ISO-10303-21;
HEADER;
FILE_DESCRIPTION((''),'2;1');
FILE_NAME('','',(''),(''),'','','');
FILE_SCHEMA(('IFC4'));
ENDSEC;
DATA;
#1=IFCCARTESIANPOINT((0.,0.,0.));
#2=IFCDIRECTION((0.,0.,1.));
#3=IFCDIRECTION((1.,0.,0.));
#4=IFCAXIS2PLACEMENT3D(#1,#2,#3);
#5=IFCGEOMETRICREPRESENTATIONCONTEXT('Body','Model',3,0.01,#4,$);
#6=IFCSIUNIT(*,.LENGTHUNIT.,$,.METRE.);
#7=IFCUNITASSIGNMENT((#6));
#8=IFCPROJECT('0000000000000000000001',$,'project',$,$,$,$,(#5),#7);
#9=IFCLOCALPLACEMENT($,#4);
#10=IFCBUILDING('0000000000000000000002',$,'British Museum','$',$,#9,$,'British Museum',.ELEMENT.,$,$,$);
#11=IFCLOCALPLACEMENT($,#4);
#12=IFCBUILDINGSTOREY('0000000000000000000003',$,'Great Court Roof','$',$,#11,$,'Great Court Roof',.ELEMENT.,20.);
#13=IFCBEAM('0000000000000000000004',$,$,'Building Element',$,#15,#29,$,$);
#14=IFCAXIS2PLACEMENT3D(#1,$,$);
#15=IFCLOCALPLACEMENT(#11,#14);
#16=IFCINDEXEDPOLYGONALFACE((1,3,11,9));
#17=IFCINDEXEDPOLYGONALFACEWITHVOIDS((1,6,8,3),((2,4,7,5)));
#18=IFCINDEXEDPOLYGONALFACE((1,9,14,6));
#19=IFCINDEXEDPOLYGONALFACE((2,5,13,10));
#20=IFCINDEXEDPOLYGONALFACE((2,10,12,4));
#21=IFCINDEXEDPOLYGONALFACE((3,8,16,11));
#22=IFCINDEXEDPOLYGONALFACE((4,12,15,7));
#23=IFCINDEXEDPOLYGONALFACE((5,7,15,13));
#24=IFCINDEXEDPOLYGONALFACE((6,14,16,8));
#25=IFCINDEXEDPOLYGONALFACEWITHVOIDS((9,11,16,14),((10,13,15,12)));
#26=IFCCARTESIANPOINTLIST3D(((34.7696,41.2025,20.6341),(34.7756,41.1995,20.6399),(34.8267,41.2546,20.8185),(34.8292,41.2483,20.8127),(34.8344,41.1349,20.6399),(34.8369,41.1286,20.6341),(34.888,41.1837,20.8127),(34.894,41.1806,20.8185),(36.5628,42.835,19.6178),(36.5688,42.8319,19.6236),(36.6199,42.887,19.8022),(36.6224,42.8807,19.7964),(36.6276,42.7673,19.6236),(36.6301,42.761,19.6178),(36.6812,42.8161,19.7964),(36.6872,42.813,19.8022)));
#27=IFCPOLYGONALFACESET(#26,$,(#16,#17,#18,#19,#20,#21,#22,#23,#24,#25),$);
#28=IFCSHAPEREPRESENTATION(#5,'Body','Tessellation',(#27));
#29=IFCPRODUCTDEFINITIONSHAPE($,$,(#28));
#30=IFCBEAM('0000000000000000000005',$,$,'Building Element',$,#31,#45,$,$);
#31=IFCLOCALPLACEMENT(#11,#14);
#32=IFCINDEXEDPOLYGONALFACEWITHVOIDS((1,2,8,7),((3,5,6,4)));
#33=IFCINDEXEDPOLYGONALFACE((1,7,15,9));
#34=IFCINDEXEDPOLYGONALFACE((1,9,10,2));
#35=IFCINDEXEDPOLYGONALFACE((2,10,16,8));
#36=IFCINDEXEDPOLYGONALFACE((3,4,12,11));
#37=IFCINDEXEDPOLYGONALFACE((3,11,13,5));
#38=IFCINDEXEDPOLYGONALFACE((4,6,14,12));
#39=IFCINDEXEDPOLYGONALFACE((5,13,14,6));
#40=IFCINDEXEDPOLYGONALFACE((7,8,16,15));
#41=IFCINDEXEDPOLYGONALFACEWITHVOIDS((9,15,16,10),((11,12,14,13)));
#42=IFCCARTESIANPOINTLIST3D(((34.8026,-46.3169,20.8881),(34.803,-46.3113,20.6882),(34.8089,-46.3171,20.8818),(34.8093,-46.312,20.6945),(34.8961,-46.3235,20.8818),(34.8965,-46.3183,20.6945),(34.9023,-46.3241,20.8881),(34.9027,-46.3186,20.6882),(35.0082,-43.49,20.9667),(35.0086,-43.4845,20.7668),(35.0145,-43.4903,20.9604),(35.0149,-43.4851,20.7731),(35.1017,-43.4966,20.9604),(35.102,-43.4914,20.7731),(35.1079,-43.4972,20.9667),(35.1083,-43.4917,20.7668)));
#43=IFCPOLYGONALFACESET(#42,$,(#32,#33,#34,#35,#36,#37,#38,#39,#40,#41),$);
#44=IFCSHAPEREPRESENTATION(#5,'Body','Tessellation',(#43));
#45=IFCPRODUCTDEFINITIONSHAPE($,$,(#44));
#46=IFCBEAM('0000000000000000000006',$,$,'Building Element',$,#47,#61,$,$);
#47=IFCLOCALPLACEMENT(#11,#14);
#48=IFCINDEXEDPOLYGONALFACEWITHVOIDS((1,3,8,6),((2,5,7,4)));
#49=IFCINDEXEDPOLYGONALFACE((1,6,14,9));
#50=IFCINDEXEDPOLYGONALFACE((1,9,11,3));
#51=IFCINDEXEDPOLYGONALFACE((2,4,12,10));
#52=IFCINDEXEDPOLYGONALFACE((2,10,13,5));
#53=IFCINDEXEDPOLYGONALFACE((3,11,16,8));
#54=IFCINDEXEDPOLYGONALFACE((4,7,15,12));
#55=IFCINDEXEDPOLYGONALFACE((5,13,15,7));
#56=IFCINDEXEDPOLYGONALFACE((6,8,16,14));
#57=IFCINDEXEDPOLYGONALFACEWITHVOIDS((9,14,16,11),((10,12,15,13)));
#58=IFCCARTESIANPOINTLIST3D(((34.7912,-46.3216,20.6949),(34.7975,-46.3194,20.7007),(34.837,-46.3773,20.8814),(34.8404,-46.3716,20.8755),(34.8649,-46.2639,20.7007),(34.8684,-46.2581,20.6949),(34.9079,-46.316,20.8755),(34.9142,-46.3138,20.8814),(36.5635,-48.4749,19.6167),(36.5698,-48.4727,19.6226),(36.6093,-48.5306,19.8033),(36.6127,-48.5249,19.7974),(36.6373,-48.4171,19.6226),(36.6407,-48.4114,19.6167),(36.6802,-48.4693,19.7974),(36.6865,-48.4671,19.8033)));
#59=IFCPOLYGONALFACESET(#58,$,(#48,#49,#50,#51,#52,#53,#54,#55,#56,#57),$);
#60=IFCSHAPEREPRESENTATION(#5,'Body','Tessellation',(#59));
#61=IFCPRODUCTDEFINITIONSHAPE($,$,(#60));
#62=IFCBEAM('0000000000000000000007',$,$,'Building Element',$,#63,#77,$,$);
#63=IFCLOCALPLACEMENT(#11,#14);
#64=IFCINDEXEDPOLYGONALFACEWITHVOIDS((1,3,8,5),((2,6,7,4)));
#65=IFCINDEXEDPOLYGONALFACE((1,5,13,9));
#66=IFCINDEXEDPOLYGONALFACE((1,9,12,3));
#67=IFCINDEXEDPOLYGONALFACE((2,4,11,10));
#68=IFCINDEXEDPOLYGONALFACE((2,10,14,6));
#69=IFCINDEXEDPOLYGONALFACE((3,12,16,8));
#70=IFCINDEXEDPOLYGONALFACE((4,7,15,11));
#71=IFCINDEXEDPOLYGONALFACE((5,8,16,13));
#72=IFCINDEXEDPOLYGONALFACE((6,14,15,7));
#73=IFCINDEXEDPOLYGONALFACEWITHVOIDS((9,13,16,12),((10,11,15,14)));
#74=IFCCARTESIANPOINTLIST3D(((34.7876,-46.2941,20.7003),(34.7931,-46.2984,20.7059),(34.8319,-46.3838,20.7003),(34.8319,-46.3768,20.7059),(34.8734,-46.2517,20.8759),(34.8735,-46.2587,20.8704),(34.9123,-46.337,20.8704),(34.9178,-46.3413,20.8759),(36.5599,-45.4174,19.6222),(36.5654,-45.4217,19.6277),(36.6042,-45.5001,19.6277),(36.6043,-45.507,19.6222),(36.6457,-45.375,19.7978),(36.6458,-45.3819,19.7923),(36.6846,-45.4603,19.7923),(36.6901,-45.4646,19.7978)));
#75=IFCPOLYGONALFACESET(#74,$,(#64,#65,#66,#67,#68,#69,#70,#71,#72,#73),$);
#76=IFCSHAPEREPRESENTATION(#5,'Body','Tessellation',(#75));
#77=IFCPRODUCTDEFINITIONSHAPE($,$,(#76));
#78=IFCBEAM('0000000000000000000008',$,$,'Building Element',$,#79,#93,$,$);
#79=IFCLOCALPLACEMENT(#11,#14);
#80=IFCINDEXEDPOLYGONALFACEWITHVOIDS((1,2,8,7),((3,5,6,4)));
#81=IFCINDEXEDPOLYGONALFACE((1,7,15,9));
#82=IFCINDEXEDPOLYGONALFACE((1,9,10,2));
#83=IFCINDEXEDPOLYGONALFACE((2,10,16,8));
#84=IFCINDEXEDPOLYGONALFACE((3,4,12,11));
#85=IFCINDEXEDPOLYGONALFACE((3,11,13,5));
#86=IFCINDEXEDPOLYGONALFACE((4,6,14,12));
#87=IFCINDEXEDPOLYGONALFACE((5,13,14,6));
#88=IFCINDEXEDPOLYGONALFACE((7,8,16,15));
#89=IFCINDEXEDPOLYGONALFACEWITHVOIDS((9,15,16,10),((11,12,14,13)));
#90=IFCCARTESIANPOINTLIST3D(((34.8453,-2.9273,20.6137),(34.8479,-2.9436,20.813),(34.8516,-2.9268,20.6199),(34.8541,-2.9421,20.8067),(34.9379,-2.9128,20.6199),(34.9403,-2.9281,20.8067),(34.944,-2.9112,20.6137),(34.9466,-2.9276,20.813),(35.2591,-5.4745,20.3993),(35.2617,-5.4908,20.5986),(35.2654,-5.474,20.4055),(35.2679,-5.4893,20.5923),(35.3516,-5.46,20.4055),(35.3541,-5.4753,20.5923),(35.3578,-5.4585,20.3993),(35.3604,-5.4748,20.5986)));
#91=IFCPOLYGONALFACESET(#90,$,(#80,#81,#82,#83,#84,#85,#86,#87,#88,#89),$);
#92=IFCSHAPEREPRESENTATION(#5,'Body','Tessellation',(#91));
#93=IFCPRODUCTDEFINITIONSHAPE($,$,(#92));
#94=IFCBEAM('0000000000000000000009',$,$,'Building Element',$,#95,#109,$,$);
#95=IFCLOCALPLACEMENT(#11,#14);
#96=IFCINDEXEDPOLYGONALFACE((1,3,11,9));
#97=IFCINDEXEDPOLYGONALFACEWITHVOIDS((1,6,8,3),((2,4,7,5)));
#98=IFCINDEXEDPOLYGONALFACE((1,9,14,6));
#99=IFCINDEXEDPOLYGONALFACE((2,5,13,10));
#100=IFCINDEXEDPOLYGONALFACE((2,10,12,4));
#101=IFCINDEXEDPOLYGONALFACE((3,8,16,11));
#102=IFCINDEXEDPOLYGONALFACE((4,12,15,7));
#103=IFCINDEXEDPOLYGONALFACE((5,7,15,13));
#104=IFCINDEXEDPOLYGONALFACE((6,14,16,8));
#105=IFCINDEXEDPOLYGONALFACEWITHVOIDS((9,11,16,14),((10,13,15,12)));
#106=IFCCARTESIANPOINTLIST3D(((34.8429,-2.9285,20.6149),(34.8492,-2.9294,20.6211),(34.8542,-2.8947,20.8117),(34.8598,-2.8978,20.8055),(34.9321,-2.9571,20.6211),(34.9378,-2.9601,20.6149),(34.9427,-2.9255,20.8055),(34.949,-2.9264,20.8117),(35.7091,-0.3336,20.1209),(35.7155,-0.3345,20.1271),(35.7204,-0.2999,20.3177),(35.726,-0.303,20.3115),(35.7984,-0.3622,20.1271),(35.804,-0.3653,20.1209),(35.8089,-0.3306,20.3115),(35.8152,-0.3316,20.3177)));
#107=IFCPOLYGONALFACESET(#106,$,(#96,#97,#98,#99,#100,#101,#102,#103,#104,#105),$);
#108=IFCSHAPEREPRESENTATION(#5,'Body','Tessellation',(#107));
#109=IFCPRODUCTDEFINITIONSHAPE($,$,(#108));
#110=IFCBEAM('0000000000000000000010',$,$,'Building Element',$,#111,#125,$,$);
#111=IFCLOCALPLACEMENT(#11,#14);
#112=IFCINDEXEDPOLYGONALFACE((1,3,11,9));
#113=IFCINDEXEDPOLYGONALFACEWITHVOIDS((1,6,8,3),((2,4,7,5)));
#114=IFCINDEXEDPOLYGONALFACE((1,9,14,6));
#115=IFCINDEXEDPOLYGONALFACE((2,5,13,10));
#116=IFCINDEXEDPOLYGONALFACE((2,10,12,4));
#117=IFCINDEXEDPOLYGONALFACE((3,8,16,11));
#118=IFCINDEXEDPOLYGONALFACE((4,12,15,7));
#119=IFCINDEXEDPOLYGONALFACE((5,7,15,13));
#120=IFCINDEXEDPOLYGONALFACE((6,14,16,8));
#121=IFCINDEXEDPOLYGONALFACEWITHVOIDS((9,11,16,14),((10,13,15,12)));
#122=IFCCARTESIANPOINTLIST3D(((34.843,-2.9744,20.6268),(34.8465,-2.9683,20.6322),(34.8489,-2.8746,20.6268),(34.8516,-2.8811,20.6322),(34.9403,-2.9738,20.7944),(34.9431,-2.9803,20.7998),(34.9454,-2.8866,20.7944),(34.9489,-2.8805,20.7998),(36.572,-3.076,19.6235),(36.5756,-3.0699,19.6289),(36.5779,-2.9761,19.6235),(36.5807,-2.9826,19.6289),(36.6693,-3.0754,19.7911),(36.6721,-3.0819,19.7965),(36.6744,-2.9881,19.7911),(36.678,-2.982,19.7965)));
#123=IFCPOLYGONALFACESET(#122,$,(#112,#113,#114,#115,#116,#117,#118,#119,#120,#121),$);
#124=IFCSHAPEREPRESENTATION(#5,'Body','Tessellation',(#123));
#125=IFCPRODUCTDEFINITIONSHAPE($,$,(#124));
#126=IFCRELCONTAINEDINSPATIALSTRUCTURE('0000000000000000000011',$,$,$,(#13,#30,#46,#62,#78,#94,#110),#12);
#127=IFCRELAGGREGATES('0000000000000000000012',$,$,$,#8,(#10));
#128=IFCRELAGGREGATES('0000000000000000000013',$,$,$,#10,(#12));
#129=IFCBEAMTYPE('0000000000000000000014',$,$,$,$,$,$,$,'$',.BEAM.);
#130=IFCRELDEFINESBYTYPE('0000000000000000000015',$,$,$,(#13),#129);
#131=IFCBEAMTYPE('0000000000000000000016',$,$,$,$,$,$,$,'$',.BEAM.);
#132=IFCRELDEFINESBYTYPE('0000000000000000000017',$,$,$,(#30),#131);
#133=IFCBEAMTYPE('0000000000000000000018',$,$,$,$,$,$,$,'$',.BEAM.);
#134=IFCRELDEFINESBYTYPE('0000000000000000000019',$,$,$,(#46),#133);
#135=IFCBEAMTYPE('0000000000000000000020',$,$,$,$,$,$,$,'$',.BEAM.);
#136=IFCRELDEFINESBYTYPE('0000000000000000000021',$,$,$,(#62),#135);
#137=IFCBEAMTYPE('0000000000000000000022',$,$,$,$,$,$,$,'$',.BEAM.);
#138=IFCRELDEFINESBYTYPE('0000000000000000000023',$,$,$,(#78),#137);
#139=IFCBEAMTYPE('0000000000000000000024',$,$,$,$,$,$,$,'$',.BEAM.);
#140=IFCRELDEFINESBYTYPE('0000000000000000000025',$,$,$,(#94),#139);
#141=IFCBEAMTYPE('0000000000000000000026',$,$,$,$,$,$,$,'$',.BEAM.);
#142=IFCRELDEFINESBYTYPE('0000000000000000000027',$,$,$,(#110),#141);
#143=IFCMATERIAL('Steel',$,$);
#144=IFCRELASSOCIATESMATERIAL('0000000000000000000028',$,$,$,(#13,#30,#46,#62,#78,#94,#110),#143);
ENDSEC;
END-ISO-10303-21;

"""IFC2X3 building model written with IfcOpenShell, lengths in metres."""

from ifc_helpers import new_model, si_unit, frame, origin_with_axes, origin_2d, place, context, project, spatial, hollow_rectangle, extrude, material, type_object, element, save


model = new_model("IFC2X3")

# Units and contexts
model_context = context("Model", 3, precision=0.01, world=origin_with_axes(), identifier="Body")
ifc_project = project(units=[si_unit("LENGTHUNIT", "METRE")], contexts=[model_context])

# Building, storey
building_placement = place(None, origin_with_axes())
building = spatial("IfcBuilding", under=ifc_project, at=building_placement, Name="British Museum", Description="$", LongName="British Museum", CompositionType="ELEMENT")
storey_placement = place(None, origin_with_axes())
storey = spatial("IfcBuildingStorey", under=building, at=storey_placement, Name="Great Court Roof", Description="$", LongName="Great Court Roof", CompositionType="ELEMENT", Elevation=20.0)

# Beams
ifc_material = material(Name="Steel")
beam_type_1 = type_object("IfcBeamType", ElementType="$", PredefinedType="BEAM")
beam_1_placement = place(None, origin_with_axes())
element("IfcBeam", 1, at=beam_1_placement, inside=storey, type_object=beam_type_1, material=ifc_material, Description="Building Element", context=model_context, shape_type="SweptSolid", body=[
    extrude(hollow_rectangle(XDim=0.1, YDim=0.2, WallThickness=0.0063, InnerFilletRadius=-0.0063, OuterFilletRadius=0.0, at=origin_2d()), frame((34.8318, 41.1916, 20.7263), z_axis=(0.682008, 0.620855, -0.386527), x_axis=(-0.673176, 0.739482, 0.0)), (0.0, 0.0, 1.0), 2.6293),
])
beam_type_2 = type_object("IfcBeamType", ElementType="$", PredefinedType="BEAM")
beam_2_placement = place(None, origin_with_axes())
element("IfcBeam", 2, at=beam_2_placement, inside=storey, type_object=beam_type_2, material=ifc_material, Description="Building Element", context=model_context, shape_type="SweptSolid", body=[
    extrude(hollow_rectangle(XDim=0.1, YDim=0.2, WallThickness=0.0063, InnerFilletRadius=-0.0063, OuterFilletRadius=0.0, at=origin_2d()), frame((34.8527, -46.3177, 20.7881), z_axis=(0.072508, 0.996982, 0.027728), x_axis=(-0.997366, 0.072536, 0.0)), (0.0, 0.0, 1.0), 2.8354),
])
beam_type_3 = type_object("IfcBeamType", ElementType="$", PredefinedType="BEAM")
beam_3_placement = place(None, origin_with_axes())
element("IfcBeam", 3, at=beam_3_placement, inside=storey, type_object=beam_type_3, material=ifc_material, Description="Building Element", context=model_context, shape_type="SweptSolid", body=[
    extrude(hollow_rectangle(XDim=0.1, YDim=0.2, WallThickness=0.0063, InnerFilletRadius=-0.0063, OuterFilletRadius=0.0, at=origin_2d()), frame((34.8527, -46.3177, 20.7881), z_axis=(0.592748, -0.720161, -0.360582), x_axis=(0.772102, 0.635499, 0.0)), (0.0, 0.0, 1.0), 2.99),
])
beam_type_4 = type_object("IfcBeamType", ElementType="$", PredefinedType="BEAM")
beam_4_placement = place(None, origin_with_axes())
element("IfcBeam", 4, at=beam_4_placement, inside=storey, type_object=beam_type_4, material=ifc_material, Description="Building Element", context=model_context, shape_type="SweptSolid", body=[
    extrude(hollow_rectangle(XDim=0.1, YDim=0.2, WallThickness=0.0063, InnerFilletRadius=-0.0063, OuterFilletRadius=0.0, at=origin_2d()), frame((34.8527, -46.3177, 20.7881), z_axis=(0.786949, 0.38928, -0.478719), x_axis=(-0.443387, 0.89633, 0.0)), (0.0, 0.0, 1.0), 2.2521),
])
beam_type_5 = type_object("IfcBeamType", ElementType="$", PredefinedType="BEAM")
beam_5_placement = place(None, origin_with_axes())
element("IfcBeam", 5, at=beam_5_placement, inside=storey, type_object=beam_type_5, material=ifc_material, Description="Building Element", context=model_context, shape_type="SweptSolid", body=[
    extrude(hollow_rectangle(XDim=0.1, YDim=0.2, WallThickness=0.0063, InnerFilletRadius=-0.0063, OuterFilletRadius=0.0, at=origin_2d()), frame((34.896, -2.9274, 20.7133), z_axis=(0.159793, -0.983672, -0.082797), x_axis=(0.987061, 0.160344, 0.0)), (0.0, 0.0, 1.0), 2.5895),
])
beam_type_6 = type_object("IfcBeamType", ElementType="$", PredefinedType="BEAM")
beam_6_placement = place(None, origin_with_axes())
element("IfcBeam", 6, at=beam_6_placement, inside=storey, type_object=beam_type_6, material=ifc_material, Description="Building Element", context=model_context, shape_type="SweptSolid", body=[
    extrude(hollow_rectangle(XDim=0.1, YDim=0.2, WallThickness=0.0063, InnerFilletRadius=-0.0063, OuterFilletRadius=0.0, at=origin_2d()), frame((34.896, -2.9274, 20.7133), z_axis=(0.311604, 0.933444, -0.177723), x_axis=(-0.948544, 0.316645, 0.0)), (0.0, 0.0, 1.0), 2.7799),
])
beam_type_7 = type_object("IfcBeamType", ElementType="$", PredefinedType="BEAM")
beam_7_placement = place(None, origin_with_axes())
element("IfcBeam", 7, at=beam_7_placement, inside=storey, type_object=beam_type_7, material=ifc_material, Description="Building Element", context=model_context, shape_type="SweptSolid", body=[
    extrude(hollow_rectangle(XDim=0.1, YDim=0.2, WallThickness=0.0063, InnerFilletRadius=-0.0063, OuterFilletRadius=0.0, at=origin_2d()), frame((34.896, -2.9274, 20.7133), z_axis=(0.863813, -0.050739, -0.501251), x_axis=(0.058638, 0.998279, 0.0)), (0.0, 0.0, 1.0), 2.0016),
])

save(model, "model.ifc")
